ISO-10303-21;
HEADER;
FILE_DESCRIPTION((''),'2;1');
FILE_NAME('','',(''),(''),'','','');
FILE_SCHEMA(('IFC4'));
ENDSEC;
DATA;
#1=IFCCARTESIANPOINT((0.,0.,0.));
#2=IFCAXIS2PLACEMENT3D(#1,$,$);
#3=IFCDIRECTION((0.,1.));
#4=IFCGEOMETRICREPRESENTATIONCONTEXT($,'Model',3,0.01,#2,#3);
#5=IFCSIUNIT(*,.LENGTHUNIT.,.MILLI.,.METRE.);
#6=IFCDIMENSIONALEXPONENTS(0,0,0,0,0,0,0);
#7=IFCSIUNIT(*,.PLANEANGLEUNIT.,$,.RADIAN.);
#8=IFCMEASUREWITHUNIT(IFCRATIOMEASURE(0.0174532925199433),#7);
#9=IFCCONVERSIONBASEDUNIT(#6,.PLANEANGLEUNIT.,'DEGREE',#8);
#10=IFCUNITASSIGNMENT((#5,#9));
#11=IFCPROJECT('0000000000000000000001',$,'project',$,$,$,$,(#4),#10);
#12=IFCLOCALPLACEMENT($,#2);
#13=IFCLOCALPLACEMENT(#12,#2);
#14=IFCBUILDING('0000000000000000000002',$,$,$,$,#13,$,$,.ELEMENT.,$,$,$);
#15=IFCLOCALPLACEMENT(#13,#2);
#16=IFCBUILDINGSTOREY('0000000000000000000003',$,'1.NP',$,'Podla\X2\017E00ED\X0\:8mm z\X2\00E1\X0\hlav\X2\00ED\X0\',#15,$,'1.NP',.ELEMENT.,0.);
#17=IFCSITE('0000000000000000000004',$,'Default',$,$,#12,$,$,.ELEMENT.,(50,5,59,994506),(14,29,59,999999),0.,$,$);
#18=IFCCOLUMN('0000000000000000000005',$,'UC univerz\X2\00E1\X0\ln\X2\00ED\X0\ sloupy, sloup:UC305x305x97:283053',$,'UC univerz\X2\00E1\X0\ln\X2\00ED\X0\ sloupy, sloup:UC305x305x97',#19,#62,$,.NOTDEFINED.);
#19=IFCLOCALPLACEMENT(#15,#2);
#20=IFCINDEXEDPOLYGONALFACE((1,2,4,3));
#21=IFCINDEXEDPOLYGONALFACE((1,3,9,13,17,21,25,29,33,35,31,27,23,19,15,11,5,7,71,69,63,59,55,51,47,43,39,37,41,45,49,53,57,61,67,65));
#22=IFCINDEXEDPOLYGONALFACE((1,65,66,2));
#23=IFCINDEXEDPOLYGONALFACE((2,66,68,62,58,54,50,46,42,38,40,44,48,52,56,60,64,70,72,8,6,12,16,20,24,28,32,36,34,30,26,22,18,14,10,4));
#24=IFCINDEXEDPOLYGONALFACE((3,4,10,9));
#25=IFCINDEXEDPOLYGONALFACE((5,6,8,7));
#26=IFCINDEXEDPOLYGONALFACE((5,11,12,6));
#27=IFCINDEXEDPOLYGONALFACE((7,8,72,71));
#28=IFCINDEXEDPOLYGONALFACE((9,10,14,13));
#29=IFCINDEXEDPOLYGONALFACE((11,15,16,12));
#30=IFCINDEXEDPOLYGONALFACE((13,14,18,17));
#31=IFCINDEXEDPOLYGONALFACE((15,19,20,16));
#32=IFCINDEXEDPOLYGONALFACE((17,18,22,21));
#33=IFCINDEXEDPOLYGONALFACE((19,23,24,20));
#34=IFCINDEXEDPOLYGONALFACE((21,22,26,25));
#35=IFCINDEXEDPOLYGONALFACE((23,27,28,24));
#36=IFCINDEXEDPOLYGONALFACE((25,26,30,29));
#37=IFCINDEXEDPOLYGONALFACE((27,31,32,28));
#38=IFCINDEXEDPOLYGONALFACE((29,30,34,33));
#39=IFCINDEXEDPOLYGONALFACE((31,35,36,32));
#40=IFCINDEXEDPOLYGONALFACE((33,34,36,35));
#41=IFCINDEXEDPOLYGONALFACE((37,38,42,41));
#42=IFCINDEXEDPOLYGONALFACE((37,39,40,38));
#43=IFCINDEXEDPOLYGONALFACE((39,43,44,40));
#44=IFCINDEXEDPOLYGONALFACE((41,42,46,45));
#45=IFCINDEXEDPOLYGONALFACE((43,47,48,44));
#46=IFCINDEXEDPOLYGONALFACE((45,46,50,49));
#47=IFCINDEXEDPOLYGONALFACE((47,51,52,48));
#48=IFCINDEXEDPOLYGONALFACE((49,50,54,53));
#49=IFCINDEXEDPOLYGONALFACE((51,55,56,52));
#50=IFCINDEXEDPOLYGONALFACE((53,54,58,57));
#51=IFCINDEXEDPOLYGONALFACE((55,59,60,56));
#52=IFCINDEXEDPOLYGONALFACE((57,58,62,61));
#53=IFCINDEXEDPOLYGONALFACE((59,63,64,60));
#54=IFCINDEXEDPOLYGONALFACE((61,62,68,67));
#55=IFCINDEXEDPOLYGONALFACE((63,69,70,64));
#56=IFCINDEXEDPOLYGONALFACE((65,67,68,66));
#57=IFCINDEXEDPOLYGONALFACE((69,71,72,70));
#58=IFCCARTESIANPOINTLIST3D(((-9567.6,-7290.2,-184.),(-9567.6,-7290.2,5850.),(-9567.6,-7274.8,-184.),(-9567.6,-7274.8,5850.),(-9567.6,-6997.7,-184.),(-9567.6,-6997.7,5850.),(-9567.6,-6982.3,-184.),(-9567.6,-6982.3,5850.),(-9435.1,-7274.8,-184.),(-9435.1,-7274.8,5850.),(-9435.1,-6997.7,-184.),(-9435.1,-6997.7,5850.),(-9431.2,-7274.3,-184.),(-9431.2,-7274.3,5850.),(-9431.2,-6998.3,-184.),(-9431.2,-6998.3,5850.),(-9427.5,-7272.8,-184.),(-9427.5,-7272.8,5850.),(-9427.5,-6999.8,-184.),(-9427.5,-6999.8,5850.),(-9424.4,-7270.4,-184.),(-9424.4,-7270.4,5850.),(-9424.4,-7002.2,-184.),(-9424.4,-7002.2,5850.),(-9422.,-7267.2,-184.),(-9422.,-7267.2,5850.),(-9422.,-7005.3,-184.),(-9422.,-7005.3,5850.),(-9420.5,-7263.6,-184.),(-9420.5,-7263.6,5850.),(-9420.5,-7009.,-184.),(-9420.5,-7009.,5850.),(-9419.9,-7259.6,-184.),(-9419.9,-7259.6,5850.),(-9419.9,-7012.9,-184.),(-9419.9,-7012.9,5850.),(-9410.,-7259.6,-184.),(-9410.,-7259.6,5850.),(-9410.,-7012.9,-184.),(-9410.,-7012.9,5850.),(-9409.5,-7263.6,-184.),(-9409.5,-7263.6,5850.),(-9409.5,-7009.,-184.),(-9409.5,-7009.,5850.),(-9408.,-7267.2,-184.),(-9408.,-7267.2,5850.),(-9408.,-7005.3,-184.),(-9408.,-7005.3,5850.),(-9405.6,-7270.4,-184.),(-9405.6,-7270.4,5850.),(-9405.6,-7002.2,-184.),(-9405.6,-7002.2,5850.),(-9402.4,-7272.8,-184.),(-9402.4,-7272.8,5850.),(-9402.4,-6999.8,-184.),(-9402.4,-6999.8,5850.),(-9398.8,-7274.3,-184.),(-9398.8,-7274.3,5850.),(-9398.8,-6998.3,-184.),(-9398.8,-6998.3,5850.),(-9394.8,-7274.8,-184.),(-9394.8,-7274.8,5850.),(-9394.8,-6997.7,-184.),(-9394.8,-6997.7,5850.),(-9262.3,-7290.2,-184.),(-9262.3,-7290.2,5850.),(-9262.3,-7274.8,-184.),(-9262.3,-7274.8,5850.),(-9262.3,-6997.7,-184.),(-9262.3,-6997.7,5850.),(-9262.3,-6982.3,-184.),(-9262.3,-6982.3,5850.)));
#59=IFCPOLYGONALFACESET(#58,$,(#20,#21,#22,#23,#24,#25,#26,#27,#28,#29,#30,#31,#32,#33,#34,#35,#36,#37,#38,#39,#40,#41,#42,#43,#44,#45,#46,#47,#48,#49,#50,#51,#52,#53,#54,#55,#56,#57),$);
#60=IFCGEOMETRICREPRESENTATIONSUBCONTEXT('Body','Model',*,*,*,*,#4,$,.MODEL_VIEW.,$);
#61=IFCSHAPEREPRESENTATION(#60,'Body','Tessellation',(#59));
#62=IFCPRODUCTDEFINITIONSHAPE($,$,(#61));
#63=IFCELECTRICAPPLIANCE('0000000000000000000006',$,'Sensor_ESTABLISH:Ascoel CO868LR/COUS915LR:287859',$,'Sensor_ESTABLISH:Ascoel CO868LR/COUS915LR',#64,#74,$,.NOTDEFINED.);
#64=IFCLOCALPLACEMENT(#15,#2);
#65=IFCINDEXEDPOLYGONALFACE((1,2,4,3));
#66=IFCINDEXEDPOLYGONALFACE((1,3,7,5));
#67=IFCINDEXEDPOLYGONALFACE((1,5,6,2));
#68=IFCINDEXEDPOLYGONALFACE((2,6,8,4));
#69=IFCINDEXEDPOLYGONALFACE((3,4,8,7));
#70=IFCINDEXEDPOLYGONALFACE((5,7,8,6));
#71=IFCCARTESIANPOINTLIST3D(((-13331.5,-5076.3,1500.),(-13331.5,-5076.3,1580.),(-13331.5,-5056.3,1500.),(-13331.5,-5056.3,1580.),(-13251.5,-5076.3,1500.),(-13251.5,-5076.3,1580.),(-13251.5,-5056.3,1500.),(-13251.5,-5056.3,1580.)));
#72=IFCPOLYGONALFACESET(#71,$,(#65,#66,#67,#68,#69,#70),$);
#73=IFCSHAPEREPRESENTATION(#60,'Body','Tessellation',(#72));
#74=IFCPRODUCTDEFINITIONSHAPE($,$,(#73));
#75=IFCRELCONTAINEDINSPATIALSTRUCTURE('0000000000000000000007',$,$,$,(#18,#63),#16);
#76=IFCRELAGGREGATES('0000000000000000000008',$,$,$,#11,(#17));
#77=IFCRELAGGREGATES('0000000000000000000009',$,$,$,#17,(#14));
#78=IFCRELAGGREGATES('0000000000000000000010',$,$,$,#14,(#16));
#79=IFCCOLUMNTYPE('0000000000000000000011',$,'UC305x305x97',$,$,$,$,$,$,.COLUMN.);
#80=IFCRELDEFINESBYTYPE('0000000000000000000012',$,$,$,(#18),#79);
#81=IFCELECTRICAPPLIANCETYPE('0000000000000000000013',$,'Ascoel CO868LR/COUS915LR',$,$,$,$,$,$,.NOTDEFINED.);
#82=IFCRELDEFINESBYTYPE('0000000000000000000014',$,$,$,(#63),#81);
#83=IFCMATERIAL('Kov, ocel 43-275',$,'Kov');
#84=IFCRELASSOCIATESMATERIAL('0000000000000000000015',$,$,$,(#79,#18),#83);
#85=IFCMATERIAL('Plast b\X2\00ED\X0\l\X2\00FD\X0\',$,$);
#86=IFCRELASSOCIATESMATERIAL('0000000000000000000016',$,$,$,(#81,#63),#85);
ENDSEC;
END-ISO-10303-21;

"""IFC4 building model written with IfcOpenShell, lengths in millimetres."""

from ifc_helpers import new_model, entity, si_unit, converted_unit, direction, frame, frame_2d, origin, origin_2d_with_axis, place, context, subcontext, project, spatial, rectangle, i_section, extrude, source, transform, mapped, material, material_profile, profile_set, profile_usage, type_object, type_shapes, element, save


model = new_model("IFC4")

# Units and contexts
model_context = context("Model", 3, precision=0.01, world=origin(), true_north=direction((0.0, 1.0)))
body_context = subcontext(model_context, "Body", "Model", "MODEL_VIEW")
ifc_project = project(units=[si_unit("LENGTHUNIT", "METRE", prefix="MILLI"), converted_unit("PLANEANGLEUNIT", "DEGREE", entity("IfcRatioMeasure", 0.0174532925199433), si_unit("PLANEANGLEUNIT", "RADIAN"), dimensions=[0, 0, 0, 0, 0, 0, 0])], contexts=[model_context])

# Site, building, storey
site_placement = place(None, origin())
site = spatial("IfcSite", under=ifc_project, at=site_placement, Name="Default", CompositionType="ELEMENT", RefLatitude=(50, 5, 59, 994506), RefLongitude=(14, 29, 59, 999999), RefElevation=0.0)
building_placement = place(site_placement, origin())
building = spatial("IfcBuilding", under=site, at=building_placement, CompositionType="ELEMENT")
storey_placement = place(building_placement, origin())
storey = spatial("IfcBuildingStorey", under=building, at=storey_placement, Name="1.NP", ObjectType="Podlaží:8mm záhlaví", LongName="1.NP", CompositionType="ELEMENT", Elevation=0.0)

# Column
ifc_material_1 = material(Name="Kov, ocel 43-275", Category="Kov")
ifc_material_profile = material_profile(ifc_material_1, i_section(OverallWidth=305.3, OverallDepth=307.9, WebThickness=9.9, FlangeThickness=15.4, FilletRadius=15.2, at=frame_2d((0.0, 0.0), x_axis=(0.0, 1.0))), Name="UC305x305x97")
ifc_profile_set = profile_set([ifc_material_profile], Name="UC305x305x97")
ifc_profile_usage = profile_usage(ifc_profile_set)
column_type = type_object("IfcColumnType", Name="UC305x305x97", PredefinedType="COLUMN", material=ifc_profile_set)
shared_shape_1 = source(origin(), body_context, "Body", "SweptSolid", [
    extrude(i_section(OverallWidth=305.3, OverallDepth=307.9, WebThickness=9.9, FlangeThickness=15.4, FilletRadius=15.2, at=frame_2d((0.0, 0.0), x_axis=(0.0, 1.0))), frame((0.0, 0.0, -184.0), z_axis=(0.0, 0.0, 1.0), x_axis=(0.0, -1.0, 0.0)), (0.0, 0.0, 1.0), 6034.0),
])
type_shapes(column_type, [shared_shape_1])
column_placement = place(storey_placement, frame((-9415.0, -7136.3, 0.0)))
element("IfcColumn", 1, at=column_placement, inside=storey, type_object=column_type, material=ifc_profile_usage, Name="UC univerzální sloupy, sloup:UC305x305x97:283053", ObjectType="UC univerzální sloupy, sloup:UC305x305x97", PredefinedType="NOTDEFINED", context=body_context, shape_type="MappedRepresentation", body=[
    mapped(shared_shape_1, transform((0.0, 0.0, 0.0), scale=1.0)),
])

# Electric appliance
ifc_material_2 = material(Name="Plast bílý")
electric_appliance_type = type_object("IfcElectricApplianceType", Name="Ascoel CO868LR/COUS915LR", PredefinedType="NOTDEFINED", material=ifc_material_2)
shared_shape_2 = source(origin(), body_context, "Body", "SweptSolid", [
    extrude(rectangle(XDim=80.0, YDim=20.0, at=origin_2d_with_axis()), frame((0.0, 0.0, 0.0), z_axis=(0.0, 0.0, 1.0), x_axis=(-1.0, 0.0, 0.0)), (0.0, 0.0, 1.0), 80.0),
])
type_shapes(electric_appliance_type, [shared_shape_2])
electric_appliance_placement = place(storey_placement, frame((-13291.5, -5066.3, 1500.0)))
element("IfcElectricAppliance", 2, at=electric_appliance_placement, inside=storey, type_object=electric_appliance_type, material=ifc_material_2, Name="Sensor_ESTABLISH:Ascoel CO868LR/COUS915LR:287859", ObjectType="Sensor_ESTABLISH:Ascoel CO868LR/COUS915LR", PredefinedType="NOTDEFINED", context=body_context, shape_type="MappedRepresentation", body=[
    mapped(shared_shape_2, transform((0.0, 0.0, 0.0), scale=1.0)),
])

save(model, "model.ifc")
